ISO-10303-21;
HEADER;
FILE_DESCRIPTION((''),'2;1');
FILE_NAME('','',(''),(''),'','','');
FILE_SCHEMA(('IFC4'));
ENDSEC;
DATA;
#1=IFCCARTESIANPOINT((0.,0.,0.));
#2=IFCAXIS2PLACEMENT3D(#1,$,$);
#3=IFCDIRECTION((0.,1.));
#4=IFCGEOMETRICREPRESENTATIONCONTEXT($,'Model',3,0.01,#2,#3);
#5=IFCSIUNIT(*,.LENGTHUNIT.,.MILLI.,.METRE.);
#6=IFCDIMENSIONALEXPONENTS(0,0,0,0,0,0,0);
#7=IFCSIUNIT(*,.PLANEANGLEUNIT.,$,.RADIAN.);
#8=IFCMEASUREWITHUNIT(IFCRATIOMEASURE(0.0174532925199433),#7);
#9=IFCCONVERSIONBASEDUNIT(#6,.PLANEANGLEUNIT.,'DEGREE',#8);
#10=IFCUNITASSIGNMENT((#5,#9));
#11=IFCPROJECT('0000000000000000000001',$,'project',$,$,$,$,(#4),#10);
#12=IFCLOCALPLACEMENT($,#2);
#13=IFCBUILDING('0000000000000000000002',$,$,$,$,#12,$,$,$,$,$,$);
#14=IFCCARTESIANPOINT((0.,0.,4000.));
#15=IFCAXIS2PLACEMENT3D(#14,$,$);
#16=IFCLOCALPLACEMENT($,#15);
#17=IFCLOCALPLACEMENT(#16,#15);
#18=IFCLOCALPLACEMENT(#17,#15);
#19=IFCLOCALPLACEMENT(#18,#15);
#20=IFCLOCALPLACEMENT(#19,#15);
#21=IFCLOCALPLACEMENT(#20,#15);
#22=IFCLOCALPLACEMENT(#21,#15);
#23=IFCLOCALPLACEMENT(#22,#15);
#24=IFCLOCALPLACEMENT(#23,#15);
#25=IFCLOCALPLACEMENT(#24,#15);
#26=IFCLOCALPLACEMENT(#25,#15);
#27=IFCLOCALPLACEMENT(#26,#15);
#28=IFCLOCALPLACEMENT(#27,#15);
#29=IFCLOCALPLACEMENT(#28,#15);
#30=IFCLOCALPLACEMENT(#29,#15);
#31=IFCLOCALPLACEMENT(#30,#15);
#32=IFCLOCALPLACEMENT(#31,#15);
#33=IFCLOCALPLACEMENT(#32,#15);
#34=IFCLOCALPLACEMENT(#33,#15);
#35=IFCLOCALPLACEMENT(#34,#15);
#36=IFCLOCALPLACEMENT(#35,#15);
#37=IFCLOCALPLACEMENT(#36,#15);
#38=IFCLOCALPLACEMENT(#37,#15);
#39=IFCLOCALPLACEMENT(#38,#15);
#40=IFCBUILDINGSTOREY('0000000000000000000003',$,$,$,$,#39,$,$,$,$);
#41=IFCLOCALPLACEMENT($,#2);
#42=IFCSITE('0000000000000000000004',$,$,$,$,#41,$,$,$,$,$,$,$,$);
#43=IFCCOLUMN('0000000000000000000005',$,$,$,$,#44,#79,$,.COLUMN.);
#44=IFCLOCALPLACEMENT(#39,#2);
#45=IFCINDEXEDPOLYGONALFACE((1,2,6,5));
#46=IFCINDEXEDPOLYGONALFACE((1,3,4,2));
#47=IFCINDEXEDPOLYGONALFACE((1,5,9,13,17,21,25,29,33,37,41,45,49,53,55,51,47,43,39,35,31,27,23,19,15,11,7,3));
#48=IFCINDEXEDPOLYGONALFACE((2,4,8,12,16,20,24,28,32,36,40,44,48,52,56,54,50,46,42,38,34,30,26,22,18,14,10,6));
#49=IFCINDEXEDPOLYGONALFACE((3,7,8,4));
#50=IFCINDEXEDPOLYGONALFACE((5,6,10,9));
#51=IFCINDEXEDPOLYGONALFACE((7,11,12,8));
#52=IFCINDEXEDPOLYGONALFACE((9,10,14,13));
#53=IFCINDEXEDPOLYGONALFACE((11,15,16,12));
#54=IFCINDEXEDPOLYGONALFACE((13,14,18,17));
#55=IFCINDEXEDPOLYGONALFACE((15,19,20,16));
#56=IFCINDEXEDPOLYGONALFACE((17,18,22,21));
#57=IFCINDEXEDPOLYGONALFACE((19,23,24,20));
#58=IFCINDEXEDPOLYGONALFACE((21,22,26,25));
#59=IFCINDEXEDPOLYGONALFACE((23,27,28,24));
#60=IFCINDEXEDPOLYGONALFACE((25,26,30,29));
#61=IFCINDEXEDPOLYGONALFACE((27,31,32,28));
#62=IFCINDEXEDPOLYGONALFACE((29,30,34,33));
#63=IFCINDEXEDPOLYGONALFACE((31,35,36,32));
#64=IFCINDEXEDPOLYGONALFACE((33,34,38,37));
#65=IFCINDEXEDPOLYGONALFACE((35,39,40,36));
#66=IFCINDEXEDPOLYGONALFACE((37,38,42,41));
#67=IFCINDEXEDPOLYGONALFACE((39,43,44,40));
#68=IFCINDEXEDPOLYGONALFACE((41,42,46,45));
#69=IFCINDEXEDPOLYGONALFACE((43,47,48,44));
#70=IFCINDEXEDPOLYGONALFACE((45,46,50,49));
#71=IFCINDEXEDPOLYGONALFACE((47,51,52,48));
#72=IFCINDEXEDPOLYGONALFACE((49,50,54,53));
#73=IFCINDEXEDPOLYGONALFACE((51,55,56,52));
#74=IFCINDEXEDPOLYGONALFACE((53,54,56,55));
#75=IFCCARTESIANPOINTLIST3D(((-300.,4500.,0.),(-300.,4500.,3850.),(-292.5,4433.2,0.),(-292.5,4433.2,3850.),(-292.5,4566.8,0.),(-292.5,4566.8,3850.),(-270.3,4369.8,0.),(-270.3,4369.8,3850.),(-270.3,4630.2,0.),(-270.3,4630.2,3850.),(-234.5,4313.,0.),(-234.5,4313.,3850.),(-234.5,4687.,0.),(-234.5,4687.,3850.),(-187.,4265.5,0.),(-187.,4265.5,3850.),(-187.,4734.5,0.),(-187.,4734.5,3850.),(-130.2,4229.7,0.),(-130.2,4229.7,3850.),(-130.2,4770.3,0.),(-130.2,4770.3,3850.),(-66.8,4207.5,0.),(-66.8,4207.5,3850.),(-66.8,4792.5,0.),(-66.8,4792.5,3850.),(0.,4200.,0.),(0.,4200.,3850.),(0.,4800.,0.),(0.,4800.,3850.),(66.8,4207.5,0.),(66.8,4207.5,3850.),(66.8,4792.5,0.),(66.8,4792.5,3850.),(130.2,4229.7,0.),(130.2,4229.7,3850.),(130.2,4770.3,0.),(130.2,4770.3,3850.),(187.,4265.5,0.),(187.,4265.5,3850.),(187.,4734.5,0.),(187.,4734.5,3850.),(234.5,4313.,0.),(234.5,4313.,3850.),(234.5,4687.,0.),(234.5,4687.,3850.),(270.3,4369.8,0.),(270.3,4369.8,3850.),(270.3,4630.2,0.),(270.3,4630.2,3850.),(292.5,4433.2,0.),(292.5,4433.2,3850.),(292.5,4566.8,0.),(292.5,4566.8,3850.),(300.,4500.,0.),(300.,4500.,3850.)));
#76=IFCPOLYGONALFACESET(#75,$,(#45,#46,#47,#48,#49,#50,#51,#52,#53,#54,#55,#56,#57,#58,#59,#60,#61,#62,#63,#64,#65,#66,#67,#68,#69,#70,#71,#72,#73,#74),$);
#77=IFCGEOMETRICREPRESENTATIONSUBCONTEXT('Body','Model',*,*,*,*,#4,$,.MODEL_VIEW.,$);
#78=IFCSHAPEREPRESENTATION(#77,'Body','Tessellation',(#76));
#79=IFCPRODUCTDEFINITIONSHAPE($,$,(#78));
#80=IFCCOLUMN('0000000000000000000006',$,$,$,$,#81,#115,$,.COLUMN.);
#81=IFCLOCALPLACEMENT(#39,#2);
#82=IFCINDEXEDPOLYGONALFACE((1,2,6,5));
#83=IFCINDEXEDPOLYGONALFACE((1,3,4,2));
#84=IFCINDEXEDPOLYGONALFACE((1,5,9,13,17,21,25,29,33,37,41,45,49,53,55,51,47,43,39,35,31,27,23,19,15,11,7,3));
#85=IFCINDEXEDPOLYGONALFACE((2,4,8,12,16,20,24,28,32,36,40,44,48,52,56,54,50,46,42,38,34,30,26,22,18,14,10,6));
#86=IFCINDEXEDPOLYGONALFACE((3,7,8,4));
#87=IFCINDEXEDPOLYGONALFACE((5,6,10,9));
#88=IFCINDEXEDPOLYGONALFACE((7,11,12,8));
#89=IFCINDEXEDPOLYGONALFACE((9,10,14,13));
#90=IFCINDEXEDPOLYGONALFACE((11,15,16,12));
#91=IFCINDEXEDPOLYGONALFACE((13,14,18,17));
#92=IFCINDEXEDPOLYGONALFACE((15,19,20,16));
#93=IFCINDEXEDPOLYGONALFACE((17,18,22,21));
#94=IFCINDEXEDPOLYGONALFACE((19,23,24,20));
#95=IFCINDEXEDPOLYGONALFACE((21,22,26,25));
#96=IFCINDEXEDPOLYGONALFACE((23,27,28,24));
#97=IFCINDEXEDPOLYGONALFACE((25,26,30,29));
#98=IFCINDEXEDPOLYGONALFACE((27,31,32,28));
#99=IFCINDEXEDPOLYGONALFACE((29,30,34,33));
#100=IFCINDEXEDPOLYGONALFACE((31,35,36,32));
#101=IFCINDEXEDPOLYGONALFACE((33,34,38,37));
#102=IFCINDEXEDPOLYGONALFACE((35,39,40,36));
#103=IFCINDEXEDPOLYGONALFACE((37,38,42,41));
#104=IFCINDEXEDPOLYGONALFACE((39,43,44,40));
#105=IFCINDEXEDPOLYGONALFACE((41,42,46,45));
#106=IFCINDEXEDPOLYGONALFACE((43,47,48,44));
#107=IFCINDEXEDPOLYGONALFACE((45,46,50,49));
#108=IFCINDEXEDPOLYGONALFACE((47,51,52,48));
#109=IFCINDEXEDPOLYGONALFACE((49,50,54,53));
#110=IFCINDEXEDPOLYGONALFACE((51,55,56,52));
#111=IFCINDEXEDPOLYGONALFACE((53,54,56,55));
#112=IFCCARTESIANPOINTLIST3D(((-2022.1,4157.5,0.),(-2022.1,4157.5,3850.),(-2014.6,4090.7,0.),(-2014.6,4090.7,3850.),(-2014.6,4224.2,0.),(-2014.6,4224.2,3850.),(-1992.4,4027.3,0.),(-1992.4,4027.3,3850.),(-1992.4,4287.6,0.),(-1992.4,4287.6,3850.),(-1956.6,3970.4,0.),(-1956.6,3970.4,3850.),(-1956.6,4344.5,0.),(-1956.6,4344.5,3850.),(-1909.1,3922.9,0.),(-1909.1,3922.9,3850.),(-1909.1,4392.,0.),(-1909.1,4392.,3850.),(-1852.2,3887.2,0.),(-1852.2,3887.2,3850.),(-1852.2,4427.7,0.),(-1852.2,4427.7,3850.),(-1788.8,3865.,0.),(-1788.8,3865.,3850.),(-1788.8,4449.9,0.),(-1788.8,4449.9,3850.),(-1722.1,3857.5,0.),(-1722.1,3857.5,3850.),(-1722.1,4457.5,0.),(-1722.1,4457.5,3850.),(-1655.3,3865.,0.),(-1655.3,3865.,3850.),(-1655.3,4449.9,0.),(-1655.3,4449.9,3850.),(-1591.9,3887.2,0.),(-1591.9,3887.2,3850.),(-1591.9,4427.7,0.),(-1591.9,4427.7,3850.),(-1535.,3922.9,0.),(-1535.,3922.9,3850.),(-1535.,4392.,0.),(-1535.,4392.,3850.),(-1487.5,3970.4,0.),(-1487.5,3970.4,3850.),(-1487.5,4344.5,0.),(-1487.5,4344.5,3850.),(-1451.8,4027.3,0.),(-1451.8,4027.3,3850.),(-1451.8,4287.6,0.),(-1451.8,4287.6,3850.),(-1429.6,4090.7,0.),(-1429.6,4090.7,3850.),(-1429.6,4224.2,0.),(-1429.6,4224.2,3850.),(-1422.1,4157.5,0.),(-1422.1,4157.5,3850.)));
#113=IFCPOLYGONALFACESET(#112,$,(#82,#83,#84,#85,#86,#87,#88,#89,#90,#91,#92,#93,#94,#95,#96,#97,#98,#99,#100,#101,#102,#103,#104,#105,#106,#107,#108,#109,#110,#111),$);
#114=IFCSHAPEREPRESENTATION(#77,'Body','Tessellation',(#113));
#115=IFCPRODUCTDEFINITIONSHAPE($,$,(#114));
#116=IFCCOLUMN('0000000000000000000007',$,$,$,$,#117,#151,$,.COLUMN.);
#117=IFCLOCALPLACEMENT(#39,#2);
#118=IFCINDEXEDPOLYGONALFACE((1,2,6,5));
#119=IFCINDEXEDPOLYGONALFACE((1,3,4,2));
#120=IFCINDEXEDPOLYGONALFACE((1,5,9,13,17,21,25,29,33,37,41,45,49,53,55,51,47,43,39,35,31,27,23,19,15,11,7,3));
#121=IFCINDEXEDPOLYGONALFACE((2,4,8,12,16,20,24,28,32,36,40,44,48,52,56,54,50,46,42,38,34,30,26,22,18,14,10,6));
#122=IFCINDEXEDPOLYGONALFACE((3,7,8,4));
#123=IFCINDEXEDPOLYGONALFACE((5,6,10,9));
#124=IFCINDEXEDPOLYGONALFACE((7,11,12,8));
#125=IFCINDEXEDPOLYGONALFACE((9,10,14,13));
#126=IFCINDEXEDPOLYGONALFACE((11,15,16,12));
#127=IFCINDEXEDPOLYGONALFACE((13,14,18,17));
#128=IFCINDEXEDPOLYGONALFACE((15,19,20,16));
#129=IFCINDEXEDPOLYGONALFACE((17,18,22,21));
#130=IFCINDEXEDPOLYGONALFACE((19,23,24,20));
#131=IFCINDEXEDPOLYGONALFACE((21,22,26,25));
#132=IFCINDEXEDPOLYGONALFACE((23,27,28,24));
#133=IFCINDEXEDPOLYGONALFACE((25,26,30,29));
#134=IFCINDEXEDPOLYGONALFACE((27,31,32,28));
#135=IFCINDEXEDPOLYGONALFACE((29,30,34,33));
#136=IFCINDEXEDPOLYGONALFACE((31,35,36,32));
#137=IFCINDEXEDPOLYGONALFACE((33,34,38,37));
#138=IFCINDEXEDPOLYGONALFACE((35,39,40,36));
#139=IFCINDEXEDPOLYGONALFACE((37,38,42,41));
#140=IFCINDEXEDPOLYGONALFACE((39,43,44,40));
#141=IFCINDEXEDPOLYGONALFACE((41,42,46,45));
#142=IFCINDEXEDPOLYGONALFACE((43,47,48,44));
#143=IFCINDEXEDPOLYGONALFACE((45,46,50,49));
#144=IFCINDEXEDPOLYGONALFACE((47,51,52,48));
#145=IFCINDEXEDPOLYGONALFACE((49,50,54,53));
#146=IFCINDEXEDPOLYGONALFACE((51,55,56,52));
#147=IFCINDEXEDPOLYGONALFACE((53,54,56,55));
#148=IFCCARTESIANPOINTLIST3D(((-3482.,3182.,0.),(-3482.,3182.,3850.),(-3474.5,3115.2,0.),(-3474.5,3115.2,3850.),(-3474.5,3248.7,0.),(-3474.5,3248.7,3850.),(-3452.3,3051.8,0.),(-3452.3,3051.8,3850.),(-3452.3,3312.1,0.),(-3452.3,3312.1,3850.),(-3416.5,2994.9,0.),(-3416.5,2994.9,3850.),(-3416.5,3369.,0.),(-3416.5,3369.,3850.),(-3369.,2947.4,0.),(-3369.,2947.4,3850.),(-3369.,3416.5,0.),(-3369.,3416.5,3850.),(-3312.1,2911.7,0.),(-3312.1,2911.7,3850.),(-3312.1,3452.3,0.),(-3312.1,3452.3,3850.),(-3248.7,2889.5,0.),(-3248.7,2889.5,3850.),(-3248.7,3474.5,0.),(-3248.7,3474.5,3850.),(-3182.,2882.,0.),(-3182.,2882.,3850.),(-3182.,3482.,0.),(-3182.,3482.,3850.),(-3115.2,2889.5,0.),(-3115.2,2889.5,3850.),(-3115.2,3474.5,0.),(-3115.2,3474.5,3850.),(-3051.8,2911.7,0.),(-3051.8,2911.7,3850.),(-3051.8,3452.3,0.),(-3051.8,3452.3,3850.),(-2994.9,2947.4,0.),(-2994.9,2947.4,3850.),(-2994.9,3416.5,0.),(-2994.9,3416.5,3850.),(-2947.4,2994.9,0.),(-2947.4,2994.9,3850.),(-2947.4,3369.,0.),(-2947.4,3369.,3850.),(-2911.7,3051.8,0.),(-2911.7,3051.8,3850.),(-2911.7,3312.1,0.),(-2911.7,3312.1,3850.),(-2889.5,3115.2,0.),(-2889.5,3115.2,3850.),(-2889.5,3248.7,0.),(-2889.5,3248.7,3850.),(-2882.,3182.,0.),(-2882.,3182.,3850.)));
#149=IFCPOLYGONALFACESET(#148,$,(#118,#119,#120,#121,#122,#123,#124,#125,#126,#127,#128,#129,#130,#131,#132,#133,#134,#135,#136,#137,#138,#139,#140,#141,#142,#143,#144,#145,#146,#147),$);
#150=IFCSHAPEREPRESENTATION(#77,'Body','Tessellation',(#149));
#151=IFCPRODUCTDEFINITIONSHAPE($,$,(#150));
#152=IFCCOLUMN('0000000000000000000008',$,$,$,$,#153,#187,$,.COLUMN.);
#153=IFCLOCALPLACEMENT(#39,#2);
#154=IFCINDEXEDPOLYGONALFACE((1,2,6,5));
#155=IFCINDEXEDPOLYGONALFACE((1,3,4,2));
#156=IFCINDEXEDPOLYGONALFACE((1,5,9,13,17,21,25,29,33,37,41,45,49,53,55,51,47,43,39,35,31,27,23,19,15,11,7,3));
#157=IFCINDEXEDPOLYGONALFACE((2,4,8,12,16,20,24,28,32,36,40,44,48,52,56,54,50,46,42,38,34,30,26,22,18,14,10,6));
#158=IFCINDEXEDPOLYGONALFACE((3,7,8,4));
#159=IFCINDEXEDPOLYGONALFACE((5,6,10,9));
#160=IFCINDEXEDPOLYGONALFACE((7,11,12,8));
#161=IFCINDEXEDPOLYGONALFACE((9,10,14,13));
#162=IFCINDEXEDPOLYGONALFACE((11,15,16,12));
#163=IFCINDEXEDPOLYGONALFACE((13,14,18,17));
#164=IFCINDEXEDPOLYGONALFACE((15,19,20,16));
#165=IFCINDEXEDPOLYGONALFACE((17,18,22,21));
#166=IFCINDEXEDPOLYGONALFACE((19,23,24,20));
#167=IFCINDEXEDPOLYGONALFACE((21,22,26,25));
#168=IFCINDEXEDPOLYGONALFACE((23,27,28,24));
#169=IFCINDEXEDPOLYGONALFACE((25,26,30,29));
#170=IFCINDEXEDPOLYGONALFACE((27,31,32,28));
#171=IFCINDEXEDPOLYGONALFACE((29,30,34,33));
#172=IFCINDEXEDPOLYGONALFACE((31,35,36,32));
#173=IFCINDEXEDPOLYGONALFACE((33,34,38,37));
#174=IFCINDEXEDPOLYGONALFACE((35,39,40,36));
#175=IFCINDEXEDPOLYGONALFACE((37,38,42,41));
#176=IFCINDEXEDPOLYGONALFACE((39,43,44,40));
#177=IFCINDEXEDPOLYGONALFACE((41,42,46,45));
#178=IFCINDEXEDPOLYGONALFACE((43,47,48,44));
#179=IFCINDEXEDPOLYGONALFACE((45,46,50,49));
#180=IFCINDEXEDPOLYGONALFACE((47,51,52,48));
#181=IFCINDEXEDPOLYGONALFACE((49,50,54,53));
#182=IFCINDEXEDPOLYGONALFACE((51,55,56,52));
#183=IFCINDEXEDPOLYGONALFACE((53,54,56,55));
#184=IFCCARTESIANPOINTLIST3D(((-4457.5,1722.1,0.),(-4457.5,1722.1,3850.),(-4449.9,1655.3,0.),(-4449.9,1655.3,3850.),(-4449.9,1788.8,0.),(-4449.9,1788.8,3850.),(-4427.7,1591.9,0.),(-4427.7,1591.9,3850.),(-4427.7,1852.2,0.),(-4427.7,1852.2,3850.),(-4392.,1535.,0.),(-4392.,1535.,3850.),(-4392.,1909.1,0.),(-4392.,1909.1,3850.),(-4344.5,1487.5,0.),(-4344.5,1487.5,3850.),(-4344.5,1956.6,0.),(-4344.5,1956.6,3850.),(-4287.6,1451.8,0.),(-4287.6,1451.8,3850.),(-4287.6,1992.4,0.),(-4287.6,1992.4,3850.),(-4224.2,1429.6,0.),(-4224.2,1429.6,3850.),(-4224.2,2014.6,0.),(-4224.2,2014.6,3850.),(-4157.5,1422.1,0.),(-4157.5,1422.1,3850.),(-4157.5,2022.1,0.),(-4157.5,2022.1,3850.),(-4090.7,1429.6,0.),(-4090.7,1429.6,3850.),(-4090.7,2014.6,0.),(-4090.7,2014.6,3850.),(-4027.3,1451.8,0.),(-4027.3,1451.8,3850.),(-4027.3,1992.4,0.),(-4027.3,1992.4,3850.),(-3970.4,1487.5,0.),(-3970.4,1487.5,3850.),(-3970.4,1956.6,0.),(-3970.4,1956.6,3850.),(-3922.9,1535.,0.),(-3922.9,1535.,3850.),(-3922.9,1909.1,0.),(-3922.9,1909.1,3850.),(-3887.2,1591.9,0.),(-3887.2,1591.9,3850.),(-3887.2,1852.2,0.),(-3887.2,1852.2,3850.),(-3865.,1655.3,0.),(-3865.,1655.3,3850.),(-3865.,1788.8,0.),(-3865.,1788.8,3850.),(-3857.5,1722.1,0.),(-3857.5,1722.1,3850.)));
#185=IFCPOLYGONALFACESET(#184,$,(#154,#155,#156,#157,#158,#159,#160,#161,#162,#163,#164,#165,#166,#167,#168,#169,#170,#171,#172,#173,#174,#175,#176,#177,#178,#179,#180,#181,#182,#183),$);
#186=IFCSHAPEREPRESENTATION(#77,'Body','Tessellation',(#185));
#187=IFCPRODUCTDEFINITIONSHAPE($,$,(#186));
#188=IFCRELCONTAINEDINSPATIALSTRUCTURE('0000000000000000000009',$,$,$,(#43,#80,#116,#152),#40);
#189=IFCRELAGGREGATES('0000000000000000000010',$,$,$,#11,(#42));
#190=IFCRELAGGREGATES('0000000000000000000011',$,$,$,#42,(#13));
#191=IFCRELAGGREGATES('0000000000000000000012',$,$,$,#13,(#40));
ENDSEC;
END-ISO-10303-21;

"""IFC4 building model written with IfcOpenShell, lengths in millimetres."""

from ifc_helpers import new_model, entity, si_unit, converted_unit, direction, frame, origin, origin_2d, place, context, subcontext, project, spatial, circle, extrude, element, save


model = new_model("IFC4")

# Units and contexts
model_context = context("Model", 3, precision=0.01, world=origin(), true_north=direction((0.0, 1.0)))
body_context = subcontext(model_context, "Body", "Model", "MODEL_VIEW")
ifc_project = project(units=[si_unit("LENGTHUNIT", "METRE", prefix="MILLI"), converted_unit("PLANEANGLEUNIT", "DEGREE", entity("IfcRatioMeasure", 0.0174532925199433), si_unit("PLANEANGLEUNIT", "RADIAN"), dimensions=[0, 0, 0, 0, 0, 0, 0])], contexts=[model_context])

# Site, building, storey
site_placement = place(None, origin())
site = spatial("IfcSite", under=ifc_project, at=site_placement)
building_placement = place(None, origin())
building = spatial("IfcBuilding", under=site, at=building_placement)
placement_1 = place(None, frame((0.0, 0.0, 4000.0)))
placement_2 = place(placement_1, frame((0.0, 0.0, 4000.0)))
placement_3 = place(placement_2, frame((0.0, 0.0, 4000.0)))
placement_4 = place(placement_3, frame((0.0, 0.0, 4000.0)))
placement_5 = place(placement_4, frame((0.0, 0.0, 4000.0)))
placement_6 = place(placement_5, frame((0.0, 0.0, 4000.0)))
placement_7 = place(placement_6, frame((0.0, 0.0, 4000.0)))
placement_8 = place(placement_7, frame((0.0, 0.0, 4000.0)))
placement_9 = place(placement_8, frame((0.0, 0.0, 4000.0)))
placement_10 = place(placement_9, frame((0.0, 0.0, 4000.0)))
placement_11 = place(placement_10, frame((0.0, 0.0, 4000.0)))
placement_12 = place(placement_11, frame((0.0, 0.0, 4000.0)))
placement_13 = place(placement_12, frame((0.0, 0.0, 4000.0)))
placement_14 = place(placement_13, frame((0.0, 0.0, 4000.0)))
placement_15 = place(placement_14, frame((0.0, 0.0, 4000.0)))
placement_16 = place(placement_15, frame((0.0, 0.0, 4000.0)))
placement_17 = place(placement_16, frame((0.0, 0.0, 4000.0)))
placement_18 = place(placement_17, frame((0.0, 0.0, 4000.0)))
placement_19 = place(placement_18, frame((0.0, 0.0, 4000.0)))
placement_20 = place(placement_19, frame((0.0, 0.0, 4000.0)))
placement_21 = place(placement_20, frame((0.0, 0.0, 4000.0)))
placement_22 = place(placement_21, frame((0.0, 0.0, 4000.0)))
placement_23 = place(placement_22, frame((0.0, 0.0, 4000.0)))
storey_placement = place(placement_23, frame((0.0, 0.0, 4000.0)))
storey = spatial("IfcBuildingStorey", under=building, at=storey_placement)

# Columns
for number, where in (
    (1, (0.0, 4500.0, 0.0)),
    (2, (-1722.1, 4157.5, 0.0)),
    (3, (-3182.0, 3182.0, 0.0)),
    (4, (-4157.5, 1722.1, 0.0)),
):
    element("IfcColumn", number, at=place(storey_placement, frame(where)), inside=storey, PredefinedType="COLUMN", context=body_context, shape_type="SweptSolid", body=[
        extrude(circle(Radius=300.0, at=origin_2d()), origin(), (0.0, 0.0, 1.0), 3850.0),
    ])

save(model, "model.ifc")
